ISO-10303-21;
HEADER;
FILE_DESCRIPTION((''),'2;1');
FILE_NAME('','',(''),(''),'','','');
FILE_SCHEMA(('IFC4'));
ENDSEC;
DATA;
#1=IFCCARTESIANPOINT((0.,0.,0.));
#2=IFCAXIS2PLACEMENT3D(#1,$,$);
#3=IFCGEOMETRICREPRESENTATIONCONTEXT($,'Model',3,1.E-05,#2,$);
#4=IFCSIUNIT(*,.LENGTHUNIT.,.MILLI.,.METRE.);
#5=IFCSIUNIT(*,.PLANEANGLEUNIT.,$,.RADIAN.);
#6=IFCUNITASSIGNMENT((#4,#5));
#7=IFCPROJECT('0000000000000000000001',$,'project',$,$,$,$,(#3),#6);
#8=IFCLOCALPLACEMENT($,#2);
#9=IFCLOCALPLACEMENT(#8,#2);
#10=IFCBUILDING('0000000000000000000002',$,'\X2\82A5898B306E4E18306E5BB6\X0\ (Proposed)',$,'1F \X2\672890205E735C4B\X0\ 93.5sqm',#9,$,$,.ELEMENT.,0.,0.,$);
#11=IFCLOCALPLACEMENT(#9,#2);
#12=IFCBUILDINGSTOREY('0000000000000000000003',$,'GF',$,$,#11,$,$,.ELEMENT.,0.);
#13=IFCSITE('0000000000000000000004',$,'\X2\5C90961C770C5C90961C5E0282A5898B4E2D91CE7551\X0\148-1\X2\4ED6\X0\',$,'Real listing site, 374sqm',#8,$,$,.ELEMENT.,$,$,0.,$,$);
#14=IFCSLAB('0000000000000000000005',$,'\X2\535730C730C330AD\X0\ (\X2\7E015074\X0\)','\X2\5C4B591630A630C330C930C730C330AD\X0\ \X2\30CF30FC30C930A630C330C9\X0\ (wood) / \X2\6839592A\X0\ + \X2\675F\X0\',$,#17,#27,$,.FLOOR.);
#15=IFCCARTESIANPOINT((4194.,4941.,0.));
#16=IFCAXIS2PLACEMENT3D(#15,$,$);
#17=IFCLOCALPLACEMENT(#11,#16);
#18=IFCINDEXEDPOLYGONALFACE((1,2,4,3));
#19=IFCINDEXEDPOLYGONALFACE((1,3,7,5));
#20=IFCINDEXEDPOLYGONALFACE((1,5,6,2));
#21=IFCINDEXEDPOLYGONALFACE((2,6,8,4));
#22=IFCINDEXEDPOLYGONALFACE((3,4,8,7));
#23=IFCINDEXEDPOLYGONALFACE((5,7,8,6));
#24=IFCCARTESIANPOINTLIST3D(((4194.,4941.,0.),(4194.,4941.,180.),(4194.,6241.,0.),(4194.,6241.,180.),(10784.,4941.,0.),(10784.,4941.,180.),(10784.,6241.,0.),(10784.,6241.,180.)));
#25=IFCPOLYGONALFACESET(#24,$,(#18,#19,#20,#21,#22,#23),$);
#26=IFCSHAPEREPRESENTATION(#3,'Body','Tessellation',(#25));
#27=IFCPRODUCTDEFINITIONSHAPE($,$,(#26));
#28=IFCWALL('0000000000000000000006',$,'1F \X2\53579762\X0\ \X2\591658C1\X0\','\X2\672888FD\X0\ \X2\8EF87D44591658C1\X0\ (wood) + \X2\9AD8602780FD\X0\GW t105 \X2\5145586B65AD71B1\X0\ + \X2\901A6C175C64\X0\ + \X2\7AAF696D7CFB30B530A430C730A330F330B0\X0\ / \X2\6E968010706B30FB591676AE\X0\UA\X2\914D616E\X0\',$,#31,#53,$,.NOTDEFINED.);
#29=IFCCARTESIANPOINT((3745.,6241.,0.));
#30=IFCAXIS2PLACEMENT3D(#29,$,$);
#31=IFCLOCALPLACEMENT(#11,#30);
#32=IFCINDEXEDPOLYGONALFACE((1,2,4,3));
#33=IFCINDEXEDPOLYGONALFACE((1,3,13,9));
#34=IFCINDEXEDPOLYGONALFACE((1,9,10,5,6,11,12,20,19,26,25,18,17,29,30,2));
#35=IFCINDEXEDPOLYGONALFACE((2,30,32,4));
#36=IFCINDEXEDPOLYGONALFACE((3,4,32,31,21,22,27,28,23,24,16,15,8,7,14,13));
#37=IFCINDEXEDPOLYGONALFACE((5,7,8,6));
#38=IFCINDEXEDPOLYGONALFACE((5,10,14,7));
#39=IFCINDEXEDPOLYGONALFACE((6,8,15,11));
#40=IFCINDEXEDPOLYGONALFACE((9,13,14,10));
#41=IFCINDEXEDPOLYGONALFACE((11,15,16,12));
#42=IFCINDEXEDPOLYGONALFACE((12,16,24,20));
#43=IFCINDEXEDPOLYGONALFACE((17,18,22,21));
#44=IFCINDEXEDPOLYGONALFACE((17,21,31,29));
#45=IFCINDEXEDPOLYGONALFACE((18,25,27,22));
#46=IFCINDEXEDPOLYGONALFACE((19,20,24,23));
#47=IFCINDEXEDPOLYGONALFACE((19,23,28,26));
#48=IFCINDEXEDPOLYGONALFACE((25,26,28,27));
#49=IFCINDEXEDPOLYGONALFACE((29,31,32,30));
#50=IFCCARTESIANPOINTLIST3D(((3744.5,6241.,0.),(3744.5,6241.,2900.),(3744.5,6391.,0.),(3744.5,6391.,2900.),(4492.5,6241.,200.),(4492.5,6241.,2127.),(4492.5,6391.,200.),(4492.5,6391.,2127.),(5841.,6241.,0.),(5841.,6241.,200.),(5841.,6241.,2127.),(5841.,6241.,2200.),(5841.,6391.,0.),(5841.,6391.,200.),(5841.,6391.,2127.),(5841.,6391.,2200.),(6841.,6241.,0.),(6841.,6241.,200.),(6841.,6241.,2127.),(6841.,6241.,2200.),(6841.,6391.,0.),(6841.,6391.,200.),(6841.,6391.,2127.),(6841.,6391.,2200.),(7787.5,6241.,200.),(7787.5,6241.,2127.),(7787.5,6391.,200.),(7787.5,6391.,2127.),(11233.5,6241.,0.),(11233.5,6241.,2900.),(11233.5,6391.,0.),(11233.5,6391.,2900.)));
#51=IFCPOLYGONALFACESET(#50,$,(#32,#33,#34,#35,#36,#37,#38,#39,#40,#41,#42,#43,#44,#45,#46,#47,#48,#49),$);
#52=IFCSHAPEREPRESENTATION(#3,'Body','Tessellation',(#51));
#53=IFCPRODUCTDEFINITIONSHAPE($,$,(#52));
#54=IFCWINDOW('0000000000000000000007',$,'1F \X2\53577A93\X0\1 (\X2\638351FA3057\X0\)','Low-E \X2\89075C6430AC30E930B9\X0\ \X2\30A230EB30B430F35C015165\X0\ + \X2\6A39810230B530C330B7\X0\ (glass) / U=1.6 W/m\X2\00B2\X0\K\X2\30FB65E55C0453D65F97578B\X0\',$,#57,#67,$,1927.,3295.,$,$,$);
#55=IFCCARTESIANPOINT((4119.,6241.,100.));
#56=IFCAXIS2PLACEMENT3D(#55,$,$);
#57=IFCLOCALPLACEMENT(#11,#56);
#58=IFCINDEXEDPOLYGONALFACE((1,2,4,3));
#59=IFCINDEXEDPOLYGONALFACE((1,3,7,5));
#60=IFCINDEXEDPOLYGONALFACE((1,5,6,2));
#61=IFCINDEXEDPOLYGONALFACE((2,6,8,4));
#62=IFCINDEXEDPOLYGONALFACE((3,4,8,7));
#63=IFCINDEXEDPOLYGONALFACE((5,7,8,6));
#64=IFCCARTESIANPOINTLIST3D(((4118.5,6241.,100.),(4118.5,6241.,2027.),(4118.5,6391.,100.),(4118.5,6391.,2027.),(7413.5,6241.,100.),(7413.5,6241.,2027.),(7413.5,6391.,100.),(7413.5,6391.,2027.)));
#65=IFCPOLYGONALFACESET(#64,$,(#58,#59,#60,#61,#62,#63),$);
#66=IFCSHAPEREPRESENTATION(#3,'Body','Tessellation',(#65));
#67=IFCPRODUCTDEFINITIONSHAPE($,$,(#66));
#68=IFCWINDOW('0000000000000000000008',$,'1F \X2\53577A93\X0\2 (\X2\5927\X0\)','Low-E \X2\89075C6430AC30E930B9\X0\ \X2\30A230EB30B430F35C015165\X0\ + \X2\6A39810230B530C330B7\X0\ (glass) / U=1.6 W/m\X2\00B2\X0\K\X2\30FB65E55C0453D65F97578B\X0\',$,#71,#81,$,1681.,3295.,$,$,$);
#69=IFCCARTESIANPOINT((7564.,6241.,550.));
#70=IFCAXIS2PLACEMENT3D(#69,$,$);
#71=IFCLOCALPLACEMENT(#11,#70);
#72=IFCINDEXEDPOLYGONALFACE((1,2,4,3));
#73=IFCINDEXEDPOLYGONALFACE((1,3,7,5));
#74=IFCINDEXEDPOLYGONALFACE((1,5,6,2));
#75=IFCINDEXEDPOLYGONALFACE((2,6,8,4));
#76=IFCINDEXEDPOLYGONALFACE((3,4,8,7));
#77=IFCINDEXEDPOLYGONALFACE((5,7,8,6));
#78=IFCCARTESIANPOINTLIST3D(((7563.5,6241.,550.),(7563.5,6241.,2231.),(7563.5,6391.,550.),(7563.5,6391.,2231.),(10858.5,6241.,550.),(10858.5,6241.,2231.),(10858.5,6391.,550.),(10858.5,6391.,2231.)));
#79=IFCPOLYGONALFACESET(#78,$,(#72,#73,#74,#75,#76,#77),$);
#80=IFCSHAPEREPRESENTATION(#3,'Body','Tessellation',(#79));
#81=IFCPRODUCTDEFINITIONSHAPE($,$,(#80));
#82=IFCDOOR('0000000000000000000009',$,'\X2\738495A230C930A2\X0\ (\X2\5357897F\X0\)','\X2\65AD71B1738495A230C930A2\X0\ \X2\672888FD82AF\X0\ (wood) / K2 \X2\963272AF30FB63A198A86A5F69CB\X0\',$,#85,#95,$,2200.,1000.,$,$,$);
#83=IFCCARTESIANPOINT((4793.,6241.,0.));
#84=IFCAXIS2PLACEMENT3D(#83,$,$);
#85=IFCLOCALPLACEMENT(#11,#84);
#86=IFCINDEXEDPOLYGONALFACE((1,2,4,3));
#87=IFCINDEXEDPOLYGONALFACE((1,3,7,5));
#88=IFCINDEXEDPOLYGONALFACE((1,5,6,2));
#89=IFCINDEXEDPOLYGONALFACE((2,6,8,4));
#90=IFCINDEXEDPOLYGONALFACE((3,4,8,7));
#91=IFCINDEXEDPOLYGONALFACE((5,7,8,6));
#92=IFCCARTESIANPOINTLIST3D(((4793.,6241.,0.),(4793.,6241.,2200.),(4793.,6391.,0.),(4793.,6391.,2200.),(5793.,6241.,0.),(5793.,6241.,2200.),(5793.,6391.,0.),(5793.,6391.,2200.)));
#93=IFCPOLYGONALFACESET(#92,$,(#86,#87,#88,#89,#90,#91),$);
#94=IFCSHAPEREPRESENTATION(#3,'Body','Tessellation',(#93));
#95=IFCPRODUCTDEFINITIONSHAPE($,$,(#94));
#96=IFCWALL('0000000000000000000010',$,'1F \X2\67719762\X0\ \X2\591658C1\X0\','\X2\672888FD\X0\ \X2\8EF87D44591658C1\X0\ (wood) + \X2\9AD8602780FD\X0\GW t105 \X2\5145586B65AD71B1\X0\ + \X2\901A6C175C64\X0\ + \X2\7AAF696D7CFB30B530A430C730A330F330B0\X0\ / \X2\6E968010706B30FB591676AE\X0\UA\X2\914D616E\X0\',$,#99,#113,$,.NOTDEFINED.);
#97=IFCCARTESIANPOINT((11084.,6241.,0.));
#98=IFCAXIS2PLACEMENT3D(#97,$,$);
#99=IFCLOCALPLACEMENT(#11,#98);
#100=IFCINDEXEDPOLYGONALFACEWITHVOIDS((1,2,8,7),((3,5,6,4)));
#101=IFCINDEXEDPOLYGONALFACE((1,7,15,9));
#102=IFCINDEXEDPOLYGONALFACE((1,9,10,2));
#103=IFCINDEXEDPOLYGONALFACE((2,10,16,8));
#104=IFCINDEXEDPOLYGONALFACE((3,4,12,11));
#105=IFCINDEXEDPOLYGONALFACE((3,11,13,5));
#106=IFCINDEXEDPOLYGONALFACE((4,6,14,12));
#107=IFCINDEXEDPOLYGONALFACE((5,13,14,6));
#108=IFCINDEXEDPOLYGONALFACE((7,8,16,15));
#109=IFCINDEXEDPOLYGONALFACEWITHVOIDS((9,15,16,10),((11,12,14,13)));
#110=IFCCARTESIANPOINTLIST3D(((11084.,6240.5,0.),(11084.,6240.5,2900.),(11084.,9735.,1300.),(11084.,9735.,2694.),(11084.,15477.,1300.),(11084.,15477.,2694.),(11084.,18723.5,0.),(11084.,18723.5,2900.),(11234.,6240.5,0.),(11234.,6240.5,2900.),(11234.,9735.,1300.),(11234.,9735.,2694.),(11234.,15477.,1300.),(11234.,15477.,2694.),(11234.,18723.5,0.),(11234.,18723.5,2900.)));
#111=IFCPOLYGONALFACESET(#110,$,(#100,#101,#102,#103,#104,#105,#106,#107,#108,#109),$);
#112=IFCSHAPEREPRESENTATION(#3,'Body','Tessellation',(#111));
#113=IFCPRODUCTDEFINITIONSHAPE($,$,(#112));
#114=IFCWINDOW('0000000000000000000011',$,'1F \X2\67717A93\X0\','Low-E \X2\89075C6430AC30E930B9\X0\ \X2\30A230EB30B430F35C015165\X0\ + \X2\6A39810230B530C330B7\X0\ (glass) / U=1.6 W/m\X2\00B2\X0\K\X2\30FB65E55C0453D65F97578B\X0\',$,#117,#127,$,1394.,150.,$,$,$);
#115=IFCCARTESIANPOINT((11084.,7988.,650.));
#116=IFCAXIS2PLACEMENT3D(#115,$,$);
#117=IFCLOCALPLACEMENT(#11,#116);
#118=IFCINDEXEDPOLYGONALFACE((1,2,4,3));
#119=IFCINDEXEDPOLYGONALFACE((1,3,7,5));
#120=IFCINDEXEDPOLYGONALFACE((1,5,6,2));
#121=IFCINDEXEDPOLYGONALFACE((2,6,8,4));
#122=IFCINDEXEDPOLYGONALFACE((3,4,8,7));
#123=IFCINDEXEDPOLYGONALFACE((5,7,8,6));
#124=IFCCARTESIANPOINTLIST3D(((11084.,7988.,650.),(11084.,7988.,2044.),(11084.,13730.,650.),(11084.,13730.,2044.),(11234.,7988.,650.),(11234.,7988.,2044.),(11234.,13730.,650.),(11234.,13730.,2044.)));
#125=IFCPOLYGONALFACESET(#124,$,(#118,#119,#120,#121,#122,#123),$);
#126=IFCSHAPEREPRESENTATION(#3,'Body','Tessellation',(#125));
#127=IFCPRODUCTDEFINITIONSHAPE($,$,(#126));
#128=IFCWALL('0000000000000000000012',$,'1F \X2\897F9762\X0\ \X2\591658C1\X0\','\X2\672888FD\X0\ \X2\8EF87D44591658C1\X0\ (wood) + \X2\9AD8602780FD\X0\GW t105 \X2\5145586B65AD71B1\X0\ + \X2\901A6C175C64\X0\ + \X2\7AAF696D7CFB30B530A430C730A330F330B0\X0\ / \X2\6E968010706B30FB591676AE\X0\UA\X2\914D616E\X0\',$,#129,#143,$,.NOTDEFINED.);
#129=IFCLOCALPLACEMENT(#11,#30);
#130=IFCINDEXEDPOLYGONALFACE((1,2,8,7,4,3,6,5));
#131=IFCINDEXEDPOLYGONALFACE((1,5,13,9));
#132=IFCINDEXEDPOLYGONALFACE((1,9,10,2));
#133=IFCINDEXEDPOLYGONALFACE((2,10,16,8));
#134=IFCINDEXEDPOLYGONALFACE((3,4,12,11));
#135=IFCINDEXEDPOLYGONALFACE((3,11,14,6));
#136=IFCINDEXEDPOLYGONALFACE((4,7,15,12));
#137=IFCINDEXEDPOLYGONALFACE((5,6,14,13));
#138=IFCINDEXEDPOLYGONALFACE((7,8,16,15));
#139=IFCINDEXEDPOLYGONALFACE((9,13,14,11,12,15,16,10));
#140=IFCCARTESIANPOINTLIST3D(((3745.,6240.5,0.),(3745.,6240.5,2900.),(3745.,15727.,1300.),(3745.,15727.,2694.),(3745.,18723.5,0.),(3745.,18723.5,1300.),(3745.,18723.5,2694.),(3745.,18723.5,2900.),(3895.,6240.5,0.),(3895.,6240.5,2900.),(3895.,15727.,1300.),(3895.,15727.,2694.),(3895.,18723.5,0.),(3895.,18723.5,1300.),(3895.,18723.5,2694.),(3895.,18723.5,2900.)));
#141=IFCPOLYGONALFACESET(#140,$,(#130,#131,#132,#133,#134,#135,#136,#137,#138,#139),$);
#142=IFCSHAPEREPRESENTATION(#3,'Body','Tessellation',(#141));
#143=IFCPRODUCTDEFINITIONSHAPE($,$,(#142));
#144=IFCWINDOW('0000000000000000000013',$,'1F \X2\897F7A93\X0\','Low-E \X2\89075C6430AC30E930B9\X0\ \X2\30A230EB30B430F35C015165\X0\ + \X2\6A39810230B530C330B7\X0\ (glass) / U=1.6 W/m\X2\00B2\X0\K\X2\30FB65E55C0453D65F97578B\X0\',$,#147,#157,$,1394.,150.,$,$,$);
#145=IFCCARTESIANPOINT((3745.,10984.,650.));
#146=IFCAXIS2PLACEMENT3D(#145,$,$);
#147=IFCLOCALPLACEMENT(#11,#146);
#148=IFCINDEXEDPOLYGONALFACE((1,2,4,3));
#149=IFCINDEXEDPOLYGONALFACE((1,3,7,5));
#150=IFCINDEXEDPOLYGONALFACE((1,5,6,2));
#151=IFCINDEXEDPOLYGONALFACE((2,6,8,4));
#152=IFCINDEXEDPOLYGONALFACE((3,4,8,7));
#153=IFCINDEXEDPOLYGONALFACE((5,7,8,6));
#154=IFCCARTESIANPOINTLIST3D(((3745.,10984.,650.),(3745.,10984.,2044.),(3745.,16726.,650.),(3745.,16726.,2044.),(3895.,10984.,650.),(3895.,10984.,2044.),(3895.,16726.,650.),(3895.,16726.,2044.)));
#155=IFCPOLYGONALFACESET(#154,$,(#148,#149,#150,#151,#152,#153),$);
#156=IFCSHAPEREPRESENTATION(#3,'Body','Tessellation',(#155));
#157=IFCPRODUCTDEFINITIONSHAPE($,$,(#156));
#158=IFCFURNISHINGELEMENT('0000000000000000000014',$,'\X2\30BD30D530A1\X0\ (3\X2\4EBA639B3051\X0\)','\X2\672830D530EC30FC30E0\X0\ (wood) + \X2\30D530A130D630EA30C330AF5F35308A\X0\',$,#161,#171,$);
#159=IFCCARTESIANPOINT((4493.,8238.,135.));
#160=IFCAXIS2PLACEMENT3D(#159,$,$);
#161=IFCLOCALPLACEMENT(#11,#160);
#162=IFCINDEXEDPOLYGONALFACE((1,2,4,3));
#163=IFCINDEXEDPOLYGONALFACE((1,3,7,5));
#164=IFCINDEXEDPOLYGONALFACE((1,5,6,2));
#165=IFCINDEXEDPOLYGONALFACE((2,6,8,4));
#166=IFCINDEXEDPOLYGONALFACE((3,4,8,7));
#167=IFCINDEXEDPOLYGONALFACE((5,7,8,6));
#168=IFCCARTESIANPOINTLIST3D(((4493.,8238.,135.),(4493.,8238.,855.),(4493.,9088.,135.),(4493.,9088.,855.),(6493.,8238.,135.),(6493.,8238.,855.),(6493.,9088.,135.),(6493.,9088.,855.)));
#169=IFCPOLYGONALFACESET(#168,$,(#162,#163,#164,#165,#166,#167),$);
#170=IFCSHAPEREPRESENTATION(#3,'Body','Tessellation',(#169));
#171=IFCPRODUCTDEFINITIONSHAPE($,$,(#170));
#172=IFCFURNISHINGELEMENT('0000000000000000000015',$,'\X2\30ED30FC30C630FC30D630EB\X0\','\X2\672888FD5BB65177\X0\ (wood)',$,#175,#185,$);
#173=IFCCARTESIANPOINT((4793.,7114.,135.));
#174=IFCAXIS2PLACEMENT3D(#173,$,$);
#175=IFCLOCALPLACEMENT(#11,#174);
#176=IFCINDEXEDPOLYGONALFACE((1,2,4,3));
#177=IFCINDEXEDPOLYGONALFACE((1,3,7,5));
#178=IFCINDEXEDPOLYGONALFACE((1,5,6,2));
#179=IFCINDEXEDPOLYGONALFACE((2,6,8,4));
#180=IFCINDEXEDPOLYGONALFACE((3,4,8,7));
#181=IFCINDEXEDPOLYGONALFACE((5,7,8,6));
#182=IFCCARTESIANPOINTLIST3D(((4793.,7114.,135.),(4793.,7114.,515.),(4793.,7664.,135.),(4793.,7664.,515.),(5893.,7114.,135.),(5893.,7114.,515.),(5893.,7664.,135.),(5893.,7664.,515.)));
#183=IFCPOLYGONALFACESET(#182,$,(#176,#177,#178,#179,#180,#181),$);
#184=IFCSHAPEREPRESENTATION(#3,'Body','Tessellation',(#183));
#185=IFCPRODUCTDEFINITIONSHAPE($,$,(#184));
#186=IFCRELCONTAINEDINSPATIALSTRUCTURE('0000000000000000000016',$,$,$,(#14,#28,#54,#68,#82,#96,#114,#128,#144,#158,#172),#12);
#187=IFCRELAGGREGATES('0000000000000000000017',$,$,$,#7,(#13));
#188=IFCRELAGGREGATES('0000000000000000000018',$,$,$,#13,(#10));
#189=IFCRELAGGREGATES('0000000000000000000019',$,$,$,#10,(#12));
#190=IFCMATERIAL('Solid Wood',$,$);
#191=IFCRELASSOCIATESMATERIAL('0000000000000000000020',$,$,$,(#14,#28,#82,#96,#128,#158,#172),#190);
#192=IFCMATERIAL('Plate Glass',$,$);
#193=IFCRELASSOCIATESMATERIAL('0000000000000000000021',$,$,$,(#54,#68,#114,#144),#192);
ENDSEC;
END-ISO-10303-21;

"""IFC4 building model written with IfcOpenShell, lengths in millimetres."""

from ifc_helpers import new_model, si_unit, frame, frame_2d, origin, place, context, project, spatial, rectangle, extrude, material, element, fill, save


model = new_model("IFC4")

# Units and contexts
model_context = context("Model", 3, precision=1e-05, world=origin())
ifc_project = project(units=[si_unit("LENGTHUNIT", "METRE", prefix="MILLI"), si_unit("PLANEANGLEUNIT", "RADIAN")], contexts=[model_context])

# Site, building, storey
site_placement = place(None, origin())
site = spatial("IfcSite", under=ifc_project, at=site_placement, Name="岐阜県岐阜市芥見中野畑148-1他", ObjectType="Real listing site, 374sqm", CompositionType="ELEMENT", RefElevation=0.0)
building_placement = place(site_placement, origin())
building = spatial("IfcBuilding", under=site, at=building_placement, Name="芥見の丘の家 (Proposed)", ObjectType="1F 木造平屋 93.5sqm", CompositionType="ELEMENT", ElevationOfRefHeight=0.0, ElevationOfTerrain=0.0)
storey_placement = place(building_placement, origin())
storey = spatial("IfcBuildingStorey", under=building, at=storey_placement, Name="GF", CompositionType="ELEMENT", Elevation=0.0)

# Slab
ifc_material_1 = material(Name="Solid Wood")
slab_1_placement = place(storey_placement, frame((4194.0, 4941.0, 0.0)))
element("IfcSlab", 1, at=slab_1_placement, inside=storey, material=ifc_material_1, Name="南デッキ (縁側)", Description="屋外ウッドデッキ ハードウッド (wood) / 根太 + 束", PredefinedType="FLOOR", context=model_context, shape_type="SweptSolid", body=[
    extrude(rectangle(XDim=6590.0, YDim=1300.0, at=frame_2d((3295.0, 650.0))), frame((4194.0, 4941.0, 0.0)), (0.0, 0.0, 1.0), 180.0),
])

# Wall, openings, windows, door
wall_1_placement = place(storey_placement, frame((3745.0, 6241.0, 0.0)))
wall_1 = element("IfcWall", 2, at=wall_1_placement, inside=storey, material=ifc_material_1, Name="1F 南面 外壁", Description="木製 軸組外壁 (wood) + 高性能GW t105 充填断熱 + 通気層 + 窯業系サイディング / 準耐火・外皮UA配慮", PredefinedType="NOTDEFINED", context=model_context, shape_type="SweptSolid", body=[
    extrude(rectangle(XDim=7489.0, YDim=150.0, at=frame_2d((3744.0, 75.0))), frame((3745.0, 6241.0, 0.0)), (0.0, 0.0, 1.0), 2900.0),
])
opening_1_placement = place(storey_placement, frame((4119.0, 6241.0, 100.0)))
opening_1 = element("IfcOpeningElement", 3, at=opening_1_placement, cuts=wall_1, PredefinedType="NOTDEFINED", context=model_context, shape_type="SweptSolid", body=[
    extrude(rectangle(XDim=3295.0, YDim=150.0, at=frame_2d((1647.0, 75.0))), frame((4119.0, 6241.0, 100.0)), (0.0, 0.0, 1.0), 1927.0),
])
opening_2_placement = place(storey_placement, frame((7564.0, 6241.0, 550.0)))
opening_2 = element("IfcOpeningElement", 4, at=opening_2_placement, cuts=wall_1, PredefinedType="NOTDEFINED", context=model_context, shape_type="SweptSolid", body=[
    extrude(rectangle(XDim=3295.0, YDim=150.0, at=frame_2d((1647.0, 75.0))), frame((7564.0, 6241.0, 550.0)), (0.0, 0.0, 1.0), 1681.0),
])
opening_3_placement = place(storey_placement, frame((4793.0, 6241.0, 0.0)))
opening_3 = element("IfcOpeningElement", 5, at=opening_3_placement, cuts=wall_1, PredefinedType="NOTDEFINED", context=model_context, shape_type="SweptSolid", body=[
    extrude(rectangle(XDim=1000.0, YDim=150.0, at=frame_2d((500.0, 75.0))), frame((4793.0, 6241.0, 0.0)), (0.0, 0.0, 1.0), 2200.0),
])
ifc_material_2 = material(Name="Plate Glass")
window_1_placement = place(storey_placement, frame((4119.0, 6241.0, 100.0)))
window_1 = element("IfcWindow", 6, at=window_1_placement, inside=storey, material=ifc_material_2, Name="1F 南窓1 (掃出し)", Description="Low-E 複層ガラス アルゴン封入 + 樹脂サッシ (glass) / U=1.6 W/m²K・日射取得型", OverallHeight=1927.0, OverallWidth=3295.0, context=model_context, shape_type="SweptSolid", body=[
    extrude(rectangle(XDim=3295.0, YDim=150.0, at=frame_2d((1647.0, 75.0))), frame((4119.0, 6241.0, 100.0)), (0.0, 0.0, 1.0), 1927.0),
])
fill(opening_1, window_1)
window_2_placement = place(storey_placement, frame((7564.0, 6241.0, 550.0)))
window_2 = element("IfcWindow", 7, at=window_2_placement, inside=storey, material=ifc_material_2, Name="1F 南窓2 (大)", Description="Low-E 複層ガラス アルゴン封入 + 樹脂サッシ (glass) / U=1.6 W/m²K・日射取得型", OverallHeight=1681.0, OverallWidth=3295.0, context=model_context, shape_type="SweptSolid", body=[
    extrude(rectangle(XDim=3295.0, YDim=150.0, at=frame_2d((1647.0, 75.0))), frame((7564.0, 6241.0, 550.0)), (0.0, 0.0, 1.0), 1681.0),
])
fill(opening_2, window_2)
door_placement = place(storey_placement, frame((4793.0, 6241.0, 0.0)))
door = element("IfcDoor", 8, at=door_placement, inside=storey, material=ifc_material_1, Name="玄関ドア (南西)", Description="断熱玄関ドア 木製芯 (wood) / K2 防犯・採風機構", OverallHeight=2200.0, OverallWidth=1000.0, context=model_context, shape_type="SweptSolid", body=[
    extrude(rectangle(XDim=1000.0, YDim=150.0, at=frame_2d((500.0, 75.0))), frame((4793.0, 6241.0, 0.0)), (0.0, 0.0, 1.0), 2200.0),
])
fill(opening_3, door)

# Walls, openings, windows
wall_2_placement = place(storey_placement, frame((11084.0, 6241.0, 0.0)))
wall_2 = element("IfcWall", 9, at=wall_2_placement, inside=storey, material=ifc_material_1, Name="1F 東面 外壁", Description="木製 軸組外壁 (wood) + 高性能GW t105 充填断熱 + 通気層 + 窯業系サイディング / 準耐火・外皮UA配慮", PredefinedType="NOTDEFINED", context=model_context, shape_type="SweptSolid", body=[
    extrude(rectangle(XDim=150.0, YDim=12483.0, at=frame_2d((75.0, 6241.0))), frame((11084.0, 6241.0, 0.0)), (0.0, 0.0, 1.0), 2900.0),
])
opening_4_placement = place(storey_placement, frame((11084.0, 7988.0, 650.0)))
opening_4 = element("IfcOpeningElement", 10, at=opening_4_placement, cuts=wall_2, PredefinedType="NOTDEFINED", context=model_context, shape_type="SweptSolid", body=[
    extrude(rectangle(XDim=150.0, YDim=5742.0, at=frame_2d((75.0, 2871.0))), frame((11084.0, 7988.0, 650.0)), (0.0, 0.0, 1.0), 1394.0),
])
window_3_placement = place(storey_placement, frame((11084.0, 7988.0, 650.0)))
window_3 = element("IfcWindow", 11, at=window_3_placement, inside=storey, material=ifc_material_2, Name="1F 東窓", Description="Low-E 複層ガラス アルゴン封入 + 樹脂サッシ (glass) / U=1.6 W/m²K・日射取得型", OverallHeight=1394.0, OverallWidth=150.0, context=model_context, shape_type="SweptSolid", body=[
    extrude(rectangle(XDim=150.0, YDim=5742.0, at=frame_2d((75.0, 2871.0))), frame((11084.0, 7988.0, 650.0)), (0.0, 0.0, 1.0), 1394.0),
])
fill(opening_4, window_3)
wall_3_placement = place(storey_placement, frame((3745.0, 6241.0, 0.0)))
wall_3 = element("IfcWall", 12, at=wall_3_placement, inside=storey, material=ifc_material_1, Name="1F 西面 外壁", Description="木製 軸組外壁 (wood) + 高性能GW t105 充填断熱 + 通気層 + 窯業系サイディング / 準耐火・外皮UA配慮", PredefinedType="NOTDEFINED", context=model_context, shape_type="SweptSolid", body=[
    extrude(rectangle(XDim=150.0, YDim=12483.0, at=frame_2d((75.0, 6241.0))), frame((3745.0, 6241.0, 0.0)), (0.0, 0.0, 1.0), 2900.0),
])
opening_5_placement = place(storey_placement, frame((3745.0, 10984.0, 650.0)))
opening_5 = element("IfcOpeningElement", 13, at=opening_5_placement, cuts=wall_3, PredefinedType="NOTDEFINED", context=model_context, shape_type="SweptSolid", body=[
    extrude(rectangle(XDim=150.0, YDim=5742.0, at=frame_2d((75.0, 2871.0))), frame((3745.0, 10984.0, 650.0)), (0.0, 0.0, 1.0), 1394.0),
])
window_4_placement = place(storey_placement, frame((3745.0, 10984.0, 650.0)))
window_4 = element("IfcWindow", 14, at=window_4_placement, inside=storey, material=ifc_material_2, Name="1F 西窓", Description="Low-E 複層ガラス アルゴン封入 + 樹脂サッシ (glass) / U=1.6 W/m²K・日射取得型", OverallHeight=1394.0, OverallWidth=150.0, context=model_context, shape_type="SweptSolid", body=[
    extrude(rectangle(XDim=150.0, YDim=5742.0, at=frame_2d((75.0, 2871.0))), frame((3745.0, 10984.0, 650.0)), (0.0, 0.0, 1.0), 1394.0),
])
fill(opening_5, window_4)

# Furnishing elements
furnishing_1_placement = place(storey_placement, frame((4493.0, 8238.0, 135.0)))
element("IfcFurnishingElement", 15, at=furnishing_1_placement, inside=storey, material=ifc_material_1, Name="ソファ (3人掛け)", Description="木フレーム (wood) + ファブリック張り", context=model_context, shape_type="SweptSolid", body=[
    extrude(rectangle(XDim=2000.0, YDim=850.0, at=frame_2d((1000.0, 425.0))), frame((4493.0, 8238.0, 135.0)), (0.0, 0.0, 1.0), 720.0),
])
furnishing_2_placement = place(storey_placement, frame((4793.0, 7114.0, 135.0)))
element("IfcFurnishingElement", 16, at=furnishing_2_placement, inside=storey, material=ifc_material_1, Name="ローテーブル", Description="木製家具 (wood)", context=model_context, shape_type="SweptSolid", body=[
    extrude(rectangle(XDim=1100.0, YDim=550.0, at=frame_2d((550.0, 275.0))), frame((4793.0, 7114.0, 135.0)), (0.0, 0.0, 1.0), 380.0),
])

save(model, "model.ifc")
